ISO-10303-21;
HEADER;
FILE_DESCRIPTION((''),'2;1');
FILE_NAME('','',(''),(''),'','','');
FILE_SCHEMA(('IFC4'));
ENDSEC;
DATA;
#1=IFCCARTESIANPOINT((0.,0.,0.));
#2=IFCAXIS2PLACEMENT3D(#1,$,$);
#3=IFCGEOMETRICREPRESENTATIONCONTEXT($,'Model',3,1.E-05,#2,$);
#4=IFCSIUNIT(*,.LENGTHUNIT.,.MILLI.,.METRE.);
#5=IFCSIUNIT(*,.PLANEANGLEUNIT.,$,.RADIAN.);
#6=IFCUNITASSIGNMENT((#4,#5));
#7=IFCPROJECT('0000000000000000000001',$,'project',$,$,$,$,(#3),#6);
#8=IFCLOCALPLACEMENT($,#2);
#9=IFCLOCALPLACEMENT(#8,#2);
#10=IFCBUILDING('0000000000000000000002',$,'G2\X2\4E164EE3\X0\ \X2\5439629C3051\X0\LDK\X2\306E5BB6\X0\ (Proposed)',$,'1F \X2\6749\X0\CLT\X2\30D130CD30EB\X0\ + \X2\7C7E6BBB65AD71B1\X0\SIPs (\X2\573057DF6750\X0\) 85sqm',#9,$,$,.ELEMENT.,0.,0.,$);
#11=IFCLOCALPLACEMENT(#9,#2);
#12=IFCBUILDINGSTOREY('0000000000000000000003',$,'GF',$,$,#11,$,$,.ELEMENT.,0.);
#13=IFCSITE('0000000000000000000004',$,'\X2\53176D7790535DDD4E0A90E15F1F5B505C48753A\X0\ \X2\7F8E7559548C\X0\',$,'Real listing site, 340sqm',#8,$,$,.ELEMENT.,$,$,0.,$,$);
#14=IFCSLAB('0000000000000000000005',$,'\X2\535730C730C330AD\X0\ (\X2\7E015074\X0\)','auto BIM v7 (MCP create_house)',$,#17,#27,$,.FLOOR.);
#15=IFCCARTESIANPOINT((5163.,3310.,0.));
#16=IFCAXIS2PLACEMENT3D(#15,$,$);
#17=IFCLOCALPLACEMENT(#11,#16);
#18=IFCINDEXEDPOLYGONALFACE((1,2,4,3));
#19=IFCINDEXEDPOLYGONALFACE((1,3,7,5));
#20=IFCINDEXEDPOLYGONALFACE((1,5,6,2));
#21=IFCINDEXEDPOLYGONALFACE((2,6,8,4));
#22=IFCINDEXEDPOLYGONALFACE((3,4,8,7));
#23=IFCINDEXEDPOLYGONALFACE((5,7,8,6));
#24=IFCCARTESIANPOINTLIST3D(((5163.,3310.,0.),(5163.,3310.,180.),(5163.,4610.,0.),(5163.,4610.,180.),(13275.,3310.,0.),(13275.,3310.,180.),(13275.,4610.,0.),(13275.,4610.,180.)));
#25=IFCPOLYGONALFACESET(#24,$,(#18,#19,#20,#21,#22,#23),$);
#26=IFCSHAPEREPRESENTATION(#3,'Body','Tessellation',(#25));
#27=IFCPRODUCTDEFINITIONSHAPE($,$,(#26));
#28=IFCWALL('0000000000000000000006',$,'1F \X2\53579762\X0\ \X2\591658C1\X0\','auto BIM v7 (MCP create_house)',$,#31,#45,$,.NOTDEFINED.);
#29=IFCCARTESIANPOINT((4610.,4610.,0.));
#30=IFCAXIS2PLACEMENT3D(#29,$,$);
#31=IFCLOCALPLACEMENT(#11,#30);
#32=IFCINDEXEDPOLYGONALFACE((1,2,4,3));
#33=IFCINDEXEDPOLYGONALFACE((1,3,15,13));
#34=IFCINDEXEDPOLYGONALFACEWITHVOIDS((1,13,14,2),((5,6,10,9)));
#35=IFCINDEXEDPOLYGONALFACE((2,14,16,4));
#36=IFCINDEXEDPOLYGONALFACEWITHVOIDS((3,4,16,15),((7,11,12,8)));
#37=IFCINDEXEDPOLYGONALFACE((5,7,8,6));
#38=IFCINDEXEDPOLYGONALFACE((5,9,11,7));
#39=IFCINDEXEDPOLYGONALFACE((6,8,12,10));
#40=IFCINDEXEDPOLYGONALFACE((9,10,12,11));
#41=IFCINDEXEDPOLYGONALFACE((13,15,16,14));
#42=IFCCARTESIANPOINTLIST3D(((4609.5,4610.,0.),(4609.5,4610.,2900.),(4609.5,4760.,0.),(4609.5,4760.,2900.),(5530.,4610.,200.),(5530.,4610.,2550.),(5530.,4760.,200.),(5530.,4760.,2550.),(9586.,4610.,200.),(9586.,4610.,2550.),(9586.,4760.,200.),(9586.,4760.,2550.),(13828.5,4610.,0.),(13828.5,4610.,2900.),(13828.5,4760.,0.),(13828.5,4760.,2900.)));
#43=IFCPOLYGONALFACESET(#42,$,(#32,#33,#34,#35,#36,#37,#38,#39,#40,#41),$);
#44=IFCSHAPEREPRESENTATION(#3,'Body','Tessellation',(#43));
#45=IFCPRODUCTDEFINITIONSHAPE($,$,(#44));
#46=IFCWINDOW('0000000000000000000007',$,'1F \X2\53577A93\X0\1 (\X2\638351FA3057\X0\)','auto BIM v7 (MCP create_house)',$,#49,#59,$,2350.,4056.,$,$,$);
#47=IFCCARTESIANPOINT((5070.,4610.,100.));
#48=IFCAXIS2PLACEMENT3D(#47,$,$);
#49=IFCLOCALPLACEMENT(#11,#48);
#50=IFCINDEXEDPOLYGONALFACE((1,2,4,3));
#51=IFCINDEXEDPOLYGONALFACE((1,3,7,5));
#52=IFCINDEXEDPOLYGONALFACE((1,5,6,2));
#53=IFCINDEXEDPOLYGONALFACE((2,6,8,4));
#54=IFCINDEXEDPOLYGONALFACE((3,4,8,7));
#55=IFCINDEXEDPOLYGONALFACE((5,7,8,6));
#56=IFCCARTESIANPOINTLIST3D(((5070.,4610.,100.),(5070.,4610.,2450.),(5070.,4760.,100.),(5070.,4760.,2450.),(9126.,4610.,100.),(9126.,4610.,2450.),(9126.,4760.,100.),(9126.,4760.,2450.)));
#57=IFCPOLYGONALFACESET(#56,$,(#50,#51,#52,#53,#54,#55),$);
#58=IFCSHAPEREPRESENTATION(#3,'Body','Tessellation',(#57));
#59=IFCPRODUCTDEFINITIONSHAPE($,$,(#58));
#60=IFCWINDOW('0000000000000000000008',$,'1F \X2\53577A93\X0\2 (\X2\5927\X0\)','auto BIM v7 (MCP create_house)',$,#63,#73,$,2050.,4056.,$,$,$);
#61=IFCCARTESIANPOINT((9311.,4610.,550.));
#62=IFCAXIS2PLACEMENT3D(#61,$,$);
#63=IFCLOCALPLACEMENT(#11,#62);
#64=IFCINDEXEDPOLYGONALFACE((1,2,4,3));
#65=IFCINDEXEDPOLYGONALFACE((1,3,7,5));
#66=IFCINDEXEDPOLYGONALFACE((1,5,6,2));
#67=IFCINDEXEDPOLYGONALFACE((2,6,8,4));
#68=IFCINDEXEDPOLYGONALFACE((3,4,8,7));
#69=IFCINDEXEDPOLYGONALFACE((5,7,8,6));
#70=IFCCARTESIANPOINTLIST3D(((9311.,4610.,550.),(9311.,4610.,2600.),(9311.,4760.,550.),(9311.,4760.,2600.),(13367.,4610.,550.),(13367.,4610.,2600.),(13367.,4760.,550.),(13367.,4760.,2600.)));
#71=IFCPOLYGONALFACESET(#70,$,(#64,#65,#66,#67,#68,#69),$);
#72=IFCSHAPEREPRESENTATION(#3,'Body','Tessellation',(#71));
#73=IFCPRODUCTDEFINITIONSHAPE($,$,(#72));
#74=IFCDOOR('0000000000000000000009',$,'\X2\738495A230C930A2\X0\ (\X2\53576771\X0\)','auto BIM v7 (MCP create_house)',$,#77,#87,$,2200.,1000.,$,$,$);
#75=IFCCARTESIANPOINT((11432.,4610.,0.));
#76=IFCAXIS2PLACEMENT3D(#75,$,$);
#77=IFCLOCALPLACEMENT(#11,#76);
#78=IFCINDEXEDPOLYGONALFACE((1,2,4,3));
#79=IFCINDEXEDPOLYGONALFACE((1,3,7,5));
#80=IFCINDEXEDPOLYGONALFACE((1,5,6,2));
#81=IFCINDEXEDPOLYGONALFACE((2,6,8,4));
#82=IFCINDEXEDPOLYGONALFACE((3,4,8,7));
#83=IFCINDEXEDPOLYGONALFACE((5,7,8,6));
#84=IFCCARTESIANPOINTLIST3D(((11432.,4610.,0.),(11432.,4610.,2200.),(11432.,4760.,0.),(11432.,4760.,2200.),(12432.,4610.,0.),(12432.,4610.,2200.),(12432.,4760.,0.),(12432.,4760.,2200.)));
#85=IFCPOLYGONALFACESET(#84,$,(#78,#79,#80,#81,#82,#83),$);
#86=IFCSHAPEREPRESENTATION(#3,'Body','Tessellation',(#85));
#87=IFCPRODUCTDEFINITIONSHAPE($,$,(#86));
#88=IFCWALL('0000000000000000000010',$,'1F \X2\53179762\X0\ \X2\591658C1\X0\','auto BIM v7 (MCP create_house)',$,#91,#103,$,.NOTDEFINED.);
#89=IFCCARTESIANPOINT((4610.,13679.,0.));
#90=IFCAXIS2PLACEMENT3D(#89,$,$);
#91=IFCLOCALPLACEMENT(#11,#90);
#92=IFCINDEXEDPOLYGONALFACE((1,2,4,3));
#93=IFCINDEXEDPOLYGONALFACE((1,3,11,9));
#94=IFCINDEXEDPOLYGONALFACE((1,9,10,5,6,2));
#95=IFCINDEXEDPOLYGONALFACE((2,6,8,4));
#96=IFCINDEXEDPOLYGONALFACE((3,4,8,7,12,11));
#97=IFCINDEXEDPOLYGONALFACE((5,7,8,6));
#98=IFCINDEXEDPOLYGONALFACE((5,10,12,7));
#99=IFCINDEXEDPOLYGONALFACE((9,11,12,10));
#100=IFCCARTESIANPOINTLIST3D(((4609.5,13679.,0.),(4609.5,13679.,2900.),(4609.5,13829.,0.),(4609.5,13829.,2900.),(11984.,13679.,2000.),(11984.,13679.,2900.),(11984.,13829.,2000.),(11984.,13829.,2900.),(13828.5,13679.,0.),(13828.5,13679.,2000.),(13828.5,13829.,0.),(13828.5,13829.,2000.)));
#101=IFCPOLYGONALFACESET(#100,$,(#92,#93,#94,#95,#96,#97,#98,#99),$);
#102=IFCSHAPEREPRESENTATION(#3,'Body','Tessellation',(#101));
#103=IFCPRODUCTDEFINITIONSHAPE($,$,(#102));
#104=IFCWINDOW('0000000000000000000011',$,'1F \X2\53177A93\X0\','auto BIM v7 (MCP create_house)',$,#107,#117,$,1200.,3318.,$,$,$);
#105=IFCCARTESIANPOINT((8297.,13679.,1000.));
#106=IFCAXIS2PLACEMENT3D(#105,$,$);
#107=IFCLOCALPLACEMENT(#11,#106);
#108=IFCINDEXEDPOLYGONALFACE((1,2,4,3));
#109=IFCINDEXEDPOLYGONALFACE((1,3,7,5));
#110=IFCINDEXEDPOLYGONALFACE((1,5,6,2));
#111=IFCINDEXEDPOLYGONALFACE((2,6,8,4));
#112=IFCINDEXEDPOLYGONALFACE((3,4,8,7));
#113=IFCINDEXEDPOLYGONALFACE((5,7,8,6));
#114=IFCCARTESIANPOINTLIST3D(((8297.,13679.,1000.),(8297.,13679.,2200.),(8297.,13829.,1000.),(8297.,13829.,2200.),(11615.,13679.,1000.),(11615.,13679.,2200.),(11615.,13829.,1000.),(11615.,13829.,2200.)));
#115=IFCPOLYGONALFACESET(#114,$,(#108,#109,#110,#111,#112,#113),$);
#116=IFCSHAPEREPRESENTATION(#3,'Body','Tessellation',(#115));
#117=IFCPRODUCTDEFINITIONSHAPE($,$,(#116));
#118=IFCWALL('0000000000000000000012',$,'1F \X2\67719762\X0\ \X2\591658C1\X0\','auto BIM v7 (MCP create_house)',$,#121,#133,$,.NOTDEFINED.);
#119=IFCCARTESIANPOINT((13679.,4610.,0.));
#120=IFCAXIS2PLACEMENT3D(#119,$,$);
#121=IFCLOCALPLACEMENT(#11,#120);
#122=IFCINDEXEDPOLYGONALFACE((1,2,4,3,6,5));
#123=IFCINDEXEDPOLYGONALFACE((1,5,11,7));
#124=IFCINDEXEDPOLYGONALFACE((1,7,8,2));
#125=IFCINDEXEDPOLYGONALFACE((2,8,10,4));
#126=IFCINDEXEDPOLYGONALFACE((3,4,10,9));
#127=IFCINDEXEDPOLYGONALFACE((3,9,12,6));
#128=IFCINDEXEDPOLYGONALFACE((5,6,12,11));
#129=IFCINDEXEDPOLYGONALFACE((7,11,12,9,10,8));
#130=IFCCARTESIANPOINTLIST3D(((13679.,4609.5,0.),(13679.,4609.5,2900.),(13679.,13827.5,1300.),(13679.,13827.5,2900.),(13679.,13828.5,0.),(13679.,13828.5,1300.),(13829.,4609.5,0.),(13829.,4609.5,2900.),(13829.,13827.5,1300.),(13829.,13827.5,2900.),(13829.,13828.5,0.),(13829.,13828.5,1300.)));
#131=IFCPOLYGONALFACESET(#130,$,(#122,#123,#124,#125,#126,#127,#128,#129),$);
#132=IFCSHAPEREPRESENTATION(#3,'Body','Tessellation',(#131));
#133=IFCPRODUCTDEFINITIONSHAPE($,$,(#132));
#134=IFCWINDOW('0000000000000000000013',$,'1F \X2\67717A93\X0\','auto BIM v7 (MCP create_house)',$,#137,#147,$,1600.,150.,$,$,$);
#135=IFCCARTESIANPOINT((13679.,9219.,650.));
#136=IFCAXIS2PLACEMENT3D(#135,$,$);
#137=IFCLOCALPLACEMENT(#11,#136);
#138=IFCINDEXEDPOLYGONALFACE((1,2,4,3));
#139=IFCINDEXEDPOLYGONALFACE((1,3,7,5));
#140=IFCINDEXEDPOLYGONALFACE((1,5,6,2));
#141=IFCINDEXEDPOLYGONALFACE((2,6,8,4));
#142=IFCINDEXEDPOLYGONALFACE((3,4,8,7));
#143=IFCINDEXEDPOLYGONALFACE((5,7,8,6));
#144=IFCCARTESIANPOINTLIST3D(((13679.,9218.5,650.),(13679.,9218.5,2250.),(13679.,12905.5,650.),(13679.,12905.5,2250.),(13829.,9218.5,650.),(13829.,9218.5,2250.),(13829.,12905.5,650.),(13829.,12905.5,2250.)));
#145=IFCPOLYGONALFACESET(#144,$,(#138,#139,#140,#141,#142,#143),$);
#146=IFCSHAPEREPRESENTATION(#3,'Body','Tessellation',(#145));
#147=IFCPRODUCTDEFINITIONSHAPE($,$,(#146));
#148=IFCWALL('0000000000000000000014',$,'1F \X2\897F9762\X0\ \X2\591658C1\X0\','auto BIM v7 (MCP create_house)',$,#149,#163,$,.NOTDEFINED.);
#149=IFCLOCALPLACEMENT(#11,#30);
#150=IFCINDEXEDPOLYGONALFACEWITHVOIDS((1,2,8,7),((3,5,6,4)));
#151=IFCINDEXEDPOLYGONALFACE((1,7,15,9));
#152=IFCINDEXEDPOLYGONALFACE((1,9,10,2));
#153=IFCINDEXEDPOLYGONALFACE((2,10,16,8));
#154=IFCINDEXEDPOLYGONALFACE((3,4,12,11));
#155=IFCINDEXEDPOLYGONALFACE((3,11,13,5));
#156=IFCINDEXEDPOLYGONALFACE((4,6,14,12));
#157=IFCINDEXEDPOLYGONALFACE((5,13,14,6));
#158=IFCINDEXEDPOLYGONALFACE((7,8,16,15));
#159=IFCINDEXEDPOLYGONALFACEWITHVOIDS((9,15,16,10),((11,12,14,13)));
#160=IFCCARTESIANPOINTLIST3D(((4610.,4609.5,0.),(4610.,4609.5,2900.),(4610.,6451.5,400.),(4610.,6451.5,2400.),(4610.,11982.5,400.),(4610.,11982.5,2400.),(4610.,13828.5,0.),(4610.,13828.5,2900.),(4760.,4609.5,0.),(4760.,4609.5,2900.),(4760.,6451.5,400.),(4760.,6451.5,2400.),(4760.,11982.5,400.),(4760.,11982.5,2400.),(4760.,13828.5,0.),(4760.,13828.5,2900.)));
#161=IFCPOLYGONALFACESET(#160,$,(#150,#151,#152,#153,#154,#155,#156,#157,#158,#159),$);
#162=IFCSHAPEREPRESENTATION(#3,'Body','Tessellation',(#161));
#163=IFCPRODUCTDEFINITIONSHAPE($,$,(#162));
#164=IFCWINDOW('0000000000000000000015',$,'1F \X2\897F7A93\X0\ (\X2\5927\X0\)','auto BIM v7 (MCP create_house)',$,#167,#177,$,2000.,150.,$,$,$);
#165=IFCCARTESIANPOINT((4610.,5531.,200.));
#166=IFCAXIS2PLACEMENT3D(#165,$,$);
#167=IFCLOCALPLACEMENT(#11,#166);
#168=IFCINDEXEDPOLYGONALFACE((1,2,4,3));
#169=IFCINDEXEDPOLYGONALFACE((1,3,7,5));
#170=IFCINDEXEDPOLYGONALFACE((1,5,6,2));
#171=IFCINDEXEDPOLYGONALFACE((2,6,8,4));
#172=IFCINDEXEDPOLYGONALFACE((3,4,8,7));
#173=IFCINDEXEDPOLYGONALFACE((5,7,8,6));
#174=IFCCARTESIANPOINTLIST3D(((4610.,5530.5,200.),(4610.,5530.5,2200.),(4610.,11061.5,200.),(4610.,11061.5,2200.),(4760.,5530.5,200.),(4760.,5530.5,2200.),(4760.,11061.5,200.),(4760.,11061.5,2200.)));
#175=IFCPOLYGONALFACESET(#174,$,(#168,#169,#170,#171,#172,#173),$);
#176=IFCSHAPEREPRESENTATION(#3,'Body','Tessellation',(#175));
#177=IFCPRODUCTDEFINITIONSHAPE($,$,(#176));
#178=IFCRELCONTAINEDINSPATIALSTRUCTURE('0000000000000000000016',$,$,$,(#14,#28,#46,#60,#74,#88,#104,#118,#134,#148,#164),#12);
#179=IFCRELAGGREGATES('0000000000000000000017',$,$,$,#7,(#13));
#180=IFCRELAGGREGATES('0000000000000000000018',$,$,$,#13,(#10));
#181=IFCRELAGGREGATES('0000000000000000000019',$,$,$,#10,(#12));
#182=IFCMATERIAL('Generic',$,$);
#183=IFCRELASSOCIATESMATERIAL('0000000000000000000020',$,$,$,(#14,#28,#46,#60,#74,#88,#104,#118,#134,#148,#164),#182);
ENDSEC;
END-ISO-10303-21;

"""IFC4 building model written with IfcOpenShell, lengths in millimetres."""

from ifc_helpers import new_model, si_unit, frame, frame_2d, origin, place, context, project, spatial, rectangle, extrude, material, element, fill, save


model = new_model("IFC4")

# Units and contexts
model_context = context("Model", 3, precision=1e-05, world=origin())
ifc_project = project(units=[si_unit("LENGTHUNIT", "METRE", prefix="MILLI"), si_unit("PLANEANGLEUNIT", "RADIAN")], contexts=[model_context])

# Site, building, storey
site_placement = place(None, origin())
site = spatial("IfcSite", under=ifc_project, at=site_placement, Name="北海道川上郡弟子屈町 美留和", ObjectType="Real listing site, 340sqm", CompositionType="ELEMENT", RefElevation=0.0)
building_placement = place(site_placement, origin())
building = spatial("IfcBuilding", under=site, at=building_placement, Name="G2世代 吹抜けLDKの家 (Proposed)", ObjectType="1F 杉CLTパネル + 籾殻断熱SIPs (地域材) 85sqm", CompositionType="ELEMENT", ElevationOfRefHeight=0.0, ElevationOfTerrain=0.0)
storey_placement = place(building_placement, origin())
storey = spatial("IfcBuildingStorey", under=building, at=storey_placement, Name="GF", CompositionType="ELEMENT", Elevation=0.0)

# Slab
ifc_material = material(Name="Generic")
slab_1_placement = place(storey_placement, frame((5163.0, 3310.0, 0.0)))
element("IfcSlab", 1, at=slab_1_placement, inside=storey, material=ifc_material, Name="南デッキ (縁側)", Description="auto BIM v7 (MCP create_house)", PredefinedType="FLOOR", context=model_context, shape_type="SweptSolid", body=[
    extrude(rectangle(XDim=8112.0, YDim=1300.0, at=frame_2d((4056.0, 650.0))), frame((5163.0, 3310.0, 0.0)), (0.0, 0.0, 1.0), 180.0),
])

# Wall, openings, windows, door
wall_1_placement = place(storey_placement, frame((4610.0, 4610.0, 0.0)))
wall_1 = element("IfcWall", 2, at=wall_1_placement, inside=storey, material=ifc_material, Name="1F 南面 外壁", Description="auto BIM v7 (MCP create_house)", PredefinedType="NOTDEFINED", context=model_context, shape_type="SweptSolid", body=[
    extrude(rectangle(XDim=9219.0, YDim=150.0, at=frame_2d((4609.0, 75.0))), frame((4610.0, 4610.0, 0.0)), (0.0, 0.0, 1.0), 2900.0),
])
opening_1_placement = place(storey_placement, frame((5070.0, 4610.0, 100.0)))
opening_1 = element("IfcOpeningElement", 3, at=opening_1_placement, cuts=wall_1, PredefinedType="NOTDEFINED", context=model_context, shape_type="SweptSolid", body=[
    extrude(rectangle(XDim=4056.0, YDim=150.0, at=frame_2d((2028.0, 75.0))), frame((5070.0, 4610.0, 100.0)), (0.0, 0.0, 1.0), 2350.0),
])
opening_2_placement = place(storey_placement, frame((9311.0, 4610.0, 550.0)))
opening_2 = element("IfcOpeningElement", 4, at=opening_2_placement, cuts=wall_1, PredefinedType="NOTDEFINED", context=model_context, shape_type="SweptSolid", body=[
    extrude(rectangle(XDim=4056.0, YDim=150.0, at=frame_2d((2028.0, 75.0))), frame((9311.0, 4610.0, 550.0)), (0.0, 0.0, 1.0), 2050.0),
])
opening_3_placement = place(storey_placement, frame((11432.0, 4610.0, 0.0)))
opening_3 = element("IfcOpeningElement", 5, at=opening_3_placement, cuts=wall_1, PredefinedType="NOTDEFINED", context=model_context, shape_type="SweptSolid", body=[
    extrude(rectangle(XDim=1000.0, YDim=150.0, at=frame_2d((500.0, 75.0))), frame((11432.0, 4610.0, 0.0)), (0.0, 0.0, 1.0), 2200.0),
])
window_1_placement = place(storey_placement, frame((5070.0, 4610.0, 100.0)))
window_1 = element("IfcWindow", 6, at=window_1_placement, inside=storey, material=ifc_material, Name="1F 南窓1 (掃出し)", Description="auto BIM v7 (MCP create_house)", OverallHeight=2350.0, OverallWidth=4056.0, context=model_context, shape_type="SweptSolid", body=[
    extrude(rectangle(XDim=4056.0, YDim=150.0, at=frame_2d((2028.0, 75.0))), frame((5070.0, 4610.0, 100.0)), (0.0, 0.0, 1.0), 2350.0),
])
fill(opening_1, window_1)
window_2_placement = place(storey_placement, frame((9311.0, 4610.0, 550.0)))
window_2 = element("IfcWindow", 7, at=window_2_placement, inside=storey, material=ifc_material, Name="1F 南窓2 (大)", Description="auto BIM v7 (MCP create_house)", OverallHeight=2050.0, OverallWidth=4056.0, context=model_context, shape_type="SweptSolid", body=[
    extrude(rectangle(XDim=4056.0, YDim=150.0, at=frame_2d((2028.0, 75.0))), frame((9311.0, 4610.0, 550.0)), (0.0, 0.0, 1.0), 2050.0),
])
fill(opening_2, window_2)
door_placement = place(storey_placement, frame((11432.0, 4610.0, 0.0)))
door = element("IfcDoor", 8, at=door_placement, inside=storey, material=ifc_material, Name="玄関ドア (南東)", Description="auto BIM v7 (MCP create_house)", OverallHeight=2200.0, OverallWidth=1000.0, context=model_context, shape_type="SweptSolid", body=[
    extrude(rectangle(XDim=1000.0, YDim=150.0, at=frame_2d((500.0, 75.0))), frame((11432.0, 4610.0, 0.0)), (0.0, 0.0, 1.0), 2200.0),
])
fill(opening_3, door)

# Walls, openings, windows
wall_2_placement = place(storey_placement, frame((4610.0, 13679.0, 0.0)))
wall_2 = element("IfcWall", 9, at=wall_2_placement, inside=storey, material=ifc_material, Name="1F 北面 外壁", Description="auto BIM v7 (MCP create_house)", PredefinedType="NOTDEFINED", context=model_context, shape_type="SweptSolid", body=[
    extrude(rectangle(XDim=9219.0, YDim=150.0, at=frame_2d((4609.0, 75.0))), frame((4610.0, 13679.0, 0.0)), (0.0, 0.0, 1.0), 2900.0),
])
opening_4_placement = place(storey_placement, frame((8297.0, 13679.0, 1000.0)))
opening_4 = element("IfcOpeningElement", 10, at=opening_4_placement, cuts=wall_2, PredefinedType="NOTDEFINED", context=model_context, shape_type="SweptSolid", body=[
    extrude(rectangle(XDim=3318.0, YDim=150.0, at=frame_2d((1659.0, 75.0))), frame((8297.0, 13679.0, 1000.0)), (0.0, 0.0, 1.0), 1200.0),
])
window_3_placement = place(storey_placement, frame((8297.0, 13679.0, 1000.0)))
window_3 = element("IfcWindow", 11, at=window_3_placement, inside=storey, material=ifc_material, Name="1F 北窓", Description="auto BIM v7 (MCP create_house)", OverallHeight=1200.0, OverallWidth=3318.0, context=model_context, shape_type="SweptSolid", body=[
    extrude(rectangle(XDim=3318.0, YDim=150.0, at=frame_2d((1659.0, 75.0))), frame((8297.0, 13679.0, 1000.0)), (0.0, 0.0, 1.0), 1200.0),
])
fill(opening_4, window_3)
wall_3_placement = place(storey_placement, frame((13679.0, 4610.0, 0.0)))
wall_3 = element("IfcWall", 12, at=wall_3_placement, inside=storey, material=ifc_material, Name="1F 東面 外壁", Description="auto BIM v7 (MCP create_house)", PredefinedType="NOTDEFINED", context=model_context, shape_type="SweptSolid", body=[
    extrude(rectangle(XDim=150.0, YDim=9219.0, at=frame_2d((75.0, 4609.0))), frame((13679.0, 4610.0, 0.0)), (0.0, 0.0, 1.0), 2900.0),
])
opening_5_placement = place(storey_placement, frame((13679.0, 9219.0, 650.0)))
opening_5 = element("IfcOpeningElement", 13, at=opening_5_placement, cuts=wall_3, PredefinedType="NOTDEFINED", context=model_context, shape_type="SweptSolid", body=[
    extrude(rectangle(XDim=150.0, YDim=3687.0, at=frame_2d((75.0, 1843.0))), frame((13679.0, 9219.0, 650.0)), (0.0, 0.0, 1.0), 1600.0),
])
window_4_placement = place(storey_placement, frame((13679.0, 9219.0, 650.0)))
window_4 = element("IfcWindow", 14, at=window_4_placement, inside=storey, material=ifc_material, Name="1F 東窓", Description="auto BIM v7 (MCP create_house)", OverallHeight=1600.0, OverallWidth=150.0, context=model_context, shape_type="SweptSolid", body=[
    extrude(rectangle(XDim=150.0, YDim=3687.0, at=frame_2d((75.0, 1843.0))), frame((13679.0, 9219.0, 650.0)), (0.0, 0.0, 1.0), 1600.0),
])
fill(opening_5, window_4)
wall_4_placement = place(storey_placement, frame((4610.0, 4610.0, 0.0)))
wall_4 = element("IfcWall", 15, at=wall_4_placement, inside=storey, material=ifc_material, Name="1F 西面 外壁", Description="auto BIM v7 (MCP create_house)", PredefinedType="NOTDEFINED", context=model_context, shape_type="SweptSolid", body=[
    extrude(rectangle(XDim=150.0, YDim=9219.0, at=frame_2d((75.0, 4609.0))), frame((4610.0, 4610.0, 0.0)), (0.0, 0.0, 1.0), 2900.0),
])
opening_6_placement = place(storey_placement, frame((4610.0, 5531.0, 200.0)))
opening_6 = element("IfcOpeningElement", 16, at=opening_6_placement, cuts=wall_4, PredefinedType="NOTDEFINED", context=model_context, shape_type="SweptSolid", body=[
    extrude(rectangle(XDim=150.0, YDim=5531.0, at=frame_2d((75.0, 2765.0))), frame((4610.0, 5531.0, 200.0)), (0.0, 0.0, 1.0), 2000.0),
])
window_5_placement = place(storey_placement, frame((4610.0, 5531.0, 200.0)))
window_5 = element("IfcWindow", 17, at=window_5_placement, inside=storey, material=ifc_material, Name="1F 西窓 (大)", Description="auto BIM v7 (MCP create_house)", OverallHeight=2000.0, OverallWidth=150.0, context=model_context, shape_type="SweptSolid", body=[
    extrude(rectangle(XDim=150.0, YDim=5531.0, at=frame_2d((75.0, 2765.0))), frame((4610.0, 5531.0, 200.0)), (0.0, 0.0, 1.0), 2000.0),
])
fill(opening_6, window_5)

save(model, "model.ifc")
